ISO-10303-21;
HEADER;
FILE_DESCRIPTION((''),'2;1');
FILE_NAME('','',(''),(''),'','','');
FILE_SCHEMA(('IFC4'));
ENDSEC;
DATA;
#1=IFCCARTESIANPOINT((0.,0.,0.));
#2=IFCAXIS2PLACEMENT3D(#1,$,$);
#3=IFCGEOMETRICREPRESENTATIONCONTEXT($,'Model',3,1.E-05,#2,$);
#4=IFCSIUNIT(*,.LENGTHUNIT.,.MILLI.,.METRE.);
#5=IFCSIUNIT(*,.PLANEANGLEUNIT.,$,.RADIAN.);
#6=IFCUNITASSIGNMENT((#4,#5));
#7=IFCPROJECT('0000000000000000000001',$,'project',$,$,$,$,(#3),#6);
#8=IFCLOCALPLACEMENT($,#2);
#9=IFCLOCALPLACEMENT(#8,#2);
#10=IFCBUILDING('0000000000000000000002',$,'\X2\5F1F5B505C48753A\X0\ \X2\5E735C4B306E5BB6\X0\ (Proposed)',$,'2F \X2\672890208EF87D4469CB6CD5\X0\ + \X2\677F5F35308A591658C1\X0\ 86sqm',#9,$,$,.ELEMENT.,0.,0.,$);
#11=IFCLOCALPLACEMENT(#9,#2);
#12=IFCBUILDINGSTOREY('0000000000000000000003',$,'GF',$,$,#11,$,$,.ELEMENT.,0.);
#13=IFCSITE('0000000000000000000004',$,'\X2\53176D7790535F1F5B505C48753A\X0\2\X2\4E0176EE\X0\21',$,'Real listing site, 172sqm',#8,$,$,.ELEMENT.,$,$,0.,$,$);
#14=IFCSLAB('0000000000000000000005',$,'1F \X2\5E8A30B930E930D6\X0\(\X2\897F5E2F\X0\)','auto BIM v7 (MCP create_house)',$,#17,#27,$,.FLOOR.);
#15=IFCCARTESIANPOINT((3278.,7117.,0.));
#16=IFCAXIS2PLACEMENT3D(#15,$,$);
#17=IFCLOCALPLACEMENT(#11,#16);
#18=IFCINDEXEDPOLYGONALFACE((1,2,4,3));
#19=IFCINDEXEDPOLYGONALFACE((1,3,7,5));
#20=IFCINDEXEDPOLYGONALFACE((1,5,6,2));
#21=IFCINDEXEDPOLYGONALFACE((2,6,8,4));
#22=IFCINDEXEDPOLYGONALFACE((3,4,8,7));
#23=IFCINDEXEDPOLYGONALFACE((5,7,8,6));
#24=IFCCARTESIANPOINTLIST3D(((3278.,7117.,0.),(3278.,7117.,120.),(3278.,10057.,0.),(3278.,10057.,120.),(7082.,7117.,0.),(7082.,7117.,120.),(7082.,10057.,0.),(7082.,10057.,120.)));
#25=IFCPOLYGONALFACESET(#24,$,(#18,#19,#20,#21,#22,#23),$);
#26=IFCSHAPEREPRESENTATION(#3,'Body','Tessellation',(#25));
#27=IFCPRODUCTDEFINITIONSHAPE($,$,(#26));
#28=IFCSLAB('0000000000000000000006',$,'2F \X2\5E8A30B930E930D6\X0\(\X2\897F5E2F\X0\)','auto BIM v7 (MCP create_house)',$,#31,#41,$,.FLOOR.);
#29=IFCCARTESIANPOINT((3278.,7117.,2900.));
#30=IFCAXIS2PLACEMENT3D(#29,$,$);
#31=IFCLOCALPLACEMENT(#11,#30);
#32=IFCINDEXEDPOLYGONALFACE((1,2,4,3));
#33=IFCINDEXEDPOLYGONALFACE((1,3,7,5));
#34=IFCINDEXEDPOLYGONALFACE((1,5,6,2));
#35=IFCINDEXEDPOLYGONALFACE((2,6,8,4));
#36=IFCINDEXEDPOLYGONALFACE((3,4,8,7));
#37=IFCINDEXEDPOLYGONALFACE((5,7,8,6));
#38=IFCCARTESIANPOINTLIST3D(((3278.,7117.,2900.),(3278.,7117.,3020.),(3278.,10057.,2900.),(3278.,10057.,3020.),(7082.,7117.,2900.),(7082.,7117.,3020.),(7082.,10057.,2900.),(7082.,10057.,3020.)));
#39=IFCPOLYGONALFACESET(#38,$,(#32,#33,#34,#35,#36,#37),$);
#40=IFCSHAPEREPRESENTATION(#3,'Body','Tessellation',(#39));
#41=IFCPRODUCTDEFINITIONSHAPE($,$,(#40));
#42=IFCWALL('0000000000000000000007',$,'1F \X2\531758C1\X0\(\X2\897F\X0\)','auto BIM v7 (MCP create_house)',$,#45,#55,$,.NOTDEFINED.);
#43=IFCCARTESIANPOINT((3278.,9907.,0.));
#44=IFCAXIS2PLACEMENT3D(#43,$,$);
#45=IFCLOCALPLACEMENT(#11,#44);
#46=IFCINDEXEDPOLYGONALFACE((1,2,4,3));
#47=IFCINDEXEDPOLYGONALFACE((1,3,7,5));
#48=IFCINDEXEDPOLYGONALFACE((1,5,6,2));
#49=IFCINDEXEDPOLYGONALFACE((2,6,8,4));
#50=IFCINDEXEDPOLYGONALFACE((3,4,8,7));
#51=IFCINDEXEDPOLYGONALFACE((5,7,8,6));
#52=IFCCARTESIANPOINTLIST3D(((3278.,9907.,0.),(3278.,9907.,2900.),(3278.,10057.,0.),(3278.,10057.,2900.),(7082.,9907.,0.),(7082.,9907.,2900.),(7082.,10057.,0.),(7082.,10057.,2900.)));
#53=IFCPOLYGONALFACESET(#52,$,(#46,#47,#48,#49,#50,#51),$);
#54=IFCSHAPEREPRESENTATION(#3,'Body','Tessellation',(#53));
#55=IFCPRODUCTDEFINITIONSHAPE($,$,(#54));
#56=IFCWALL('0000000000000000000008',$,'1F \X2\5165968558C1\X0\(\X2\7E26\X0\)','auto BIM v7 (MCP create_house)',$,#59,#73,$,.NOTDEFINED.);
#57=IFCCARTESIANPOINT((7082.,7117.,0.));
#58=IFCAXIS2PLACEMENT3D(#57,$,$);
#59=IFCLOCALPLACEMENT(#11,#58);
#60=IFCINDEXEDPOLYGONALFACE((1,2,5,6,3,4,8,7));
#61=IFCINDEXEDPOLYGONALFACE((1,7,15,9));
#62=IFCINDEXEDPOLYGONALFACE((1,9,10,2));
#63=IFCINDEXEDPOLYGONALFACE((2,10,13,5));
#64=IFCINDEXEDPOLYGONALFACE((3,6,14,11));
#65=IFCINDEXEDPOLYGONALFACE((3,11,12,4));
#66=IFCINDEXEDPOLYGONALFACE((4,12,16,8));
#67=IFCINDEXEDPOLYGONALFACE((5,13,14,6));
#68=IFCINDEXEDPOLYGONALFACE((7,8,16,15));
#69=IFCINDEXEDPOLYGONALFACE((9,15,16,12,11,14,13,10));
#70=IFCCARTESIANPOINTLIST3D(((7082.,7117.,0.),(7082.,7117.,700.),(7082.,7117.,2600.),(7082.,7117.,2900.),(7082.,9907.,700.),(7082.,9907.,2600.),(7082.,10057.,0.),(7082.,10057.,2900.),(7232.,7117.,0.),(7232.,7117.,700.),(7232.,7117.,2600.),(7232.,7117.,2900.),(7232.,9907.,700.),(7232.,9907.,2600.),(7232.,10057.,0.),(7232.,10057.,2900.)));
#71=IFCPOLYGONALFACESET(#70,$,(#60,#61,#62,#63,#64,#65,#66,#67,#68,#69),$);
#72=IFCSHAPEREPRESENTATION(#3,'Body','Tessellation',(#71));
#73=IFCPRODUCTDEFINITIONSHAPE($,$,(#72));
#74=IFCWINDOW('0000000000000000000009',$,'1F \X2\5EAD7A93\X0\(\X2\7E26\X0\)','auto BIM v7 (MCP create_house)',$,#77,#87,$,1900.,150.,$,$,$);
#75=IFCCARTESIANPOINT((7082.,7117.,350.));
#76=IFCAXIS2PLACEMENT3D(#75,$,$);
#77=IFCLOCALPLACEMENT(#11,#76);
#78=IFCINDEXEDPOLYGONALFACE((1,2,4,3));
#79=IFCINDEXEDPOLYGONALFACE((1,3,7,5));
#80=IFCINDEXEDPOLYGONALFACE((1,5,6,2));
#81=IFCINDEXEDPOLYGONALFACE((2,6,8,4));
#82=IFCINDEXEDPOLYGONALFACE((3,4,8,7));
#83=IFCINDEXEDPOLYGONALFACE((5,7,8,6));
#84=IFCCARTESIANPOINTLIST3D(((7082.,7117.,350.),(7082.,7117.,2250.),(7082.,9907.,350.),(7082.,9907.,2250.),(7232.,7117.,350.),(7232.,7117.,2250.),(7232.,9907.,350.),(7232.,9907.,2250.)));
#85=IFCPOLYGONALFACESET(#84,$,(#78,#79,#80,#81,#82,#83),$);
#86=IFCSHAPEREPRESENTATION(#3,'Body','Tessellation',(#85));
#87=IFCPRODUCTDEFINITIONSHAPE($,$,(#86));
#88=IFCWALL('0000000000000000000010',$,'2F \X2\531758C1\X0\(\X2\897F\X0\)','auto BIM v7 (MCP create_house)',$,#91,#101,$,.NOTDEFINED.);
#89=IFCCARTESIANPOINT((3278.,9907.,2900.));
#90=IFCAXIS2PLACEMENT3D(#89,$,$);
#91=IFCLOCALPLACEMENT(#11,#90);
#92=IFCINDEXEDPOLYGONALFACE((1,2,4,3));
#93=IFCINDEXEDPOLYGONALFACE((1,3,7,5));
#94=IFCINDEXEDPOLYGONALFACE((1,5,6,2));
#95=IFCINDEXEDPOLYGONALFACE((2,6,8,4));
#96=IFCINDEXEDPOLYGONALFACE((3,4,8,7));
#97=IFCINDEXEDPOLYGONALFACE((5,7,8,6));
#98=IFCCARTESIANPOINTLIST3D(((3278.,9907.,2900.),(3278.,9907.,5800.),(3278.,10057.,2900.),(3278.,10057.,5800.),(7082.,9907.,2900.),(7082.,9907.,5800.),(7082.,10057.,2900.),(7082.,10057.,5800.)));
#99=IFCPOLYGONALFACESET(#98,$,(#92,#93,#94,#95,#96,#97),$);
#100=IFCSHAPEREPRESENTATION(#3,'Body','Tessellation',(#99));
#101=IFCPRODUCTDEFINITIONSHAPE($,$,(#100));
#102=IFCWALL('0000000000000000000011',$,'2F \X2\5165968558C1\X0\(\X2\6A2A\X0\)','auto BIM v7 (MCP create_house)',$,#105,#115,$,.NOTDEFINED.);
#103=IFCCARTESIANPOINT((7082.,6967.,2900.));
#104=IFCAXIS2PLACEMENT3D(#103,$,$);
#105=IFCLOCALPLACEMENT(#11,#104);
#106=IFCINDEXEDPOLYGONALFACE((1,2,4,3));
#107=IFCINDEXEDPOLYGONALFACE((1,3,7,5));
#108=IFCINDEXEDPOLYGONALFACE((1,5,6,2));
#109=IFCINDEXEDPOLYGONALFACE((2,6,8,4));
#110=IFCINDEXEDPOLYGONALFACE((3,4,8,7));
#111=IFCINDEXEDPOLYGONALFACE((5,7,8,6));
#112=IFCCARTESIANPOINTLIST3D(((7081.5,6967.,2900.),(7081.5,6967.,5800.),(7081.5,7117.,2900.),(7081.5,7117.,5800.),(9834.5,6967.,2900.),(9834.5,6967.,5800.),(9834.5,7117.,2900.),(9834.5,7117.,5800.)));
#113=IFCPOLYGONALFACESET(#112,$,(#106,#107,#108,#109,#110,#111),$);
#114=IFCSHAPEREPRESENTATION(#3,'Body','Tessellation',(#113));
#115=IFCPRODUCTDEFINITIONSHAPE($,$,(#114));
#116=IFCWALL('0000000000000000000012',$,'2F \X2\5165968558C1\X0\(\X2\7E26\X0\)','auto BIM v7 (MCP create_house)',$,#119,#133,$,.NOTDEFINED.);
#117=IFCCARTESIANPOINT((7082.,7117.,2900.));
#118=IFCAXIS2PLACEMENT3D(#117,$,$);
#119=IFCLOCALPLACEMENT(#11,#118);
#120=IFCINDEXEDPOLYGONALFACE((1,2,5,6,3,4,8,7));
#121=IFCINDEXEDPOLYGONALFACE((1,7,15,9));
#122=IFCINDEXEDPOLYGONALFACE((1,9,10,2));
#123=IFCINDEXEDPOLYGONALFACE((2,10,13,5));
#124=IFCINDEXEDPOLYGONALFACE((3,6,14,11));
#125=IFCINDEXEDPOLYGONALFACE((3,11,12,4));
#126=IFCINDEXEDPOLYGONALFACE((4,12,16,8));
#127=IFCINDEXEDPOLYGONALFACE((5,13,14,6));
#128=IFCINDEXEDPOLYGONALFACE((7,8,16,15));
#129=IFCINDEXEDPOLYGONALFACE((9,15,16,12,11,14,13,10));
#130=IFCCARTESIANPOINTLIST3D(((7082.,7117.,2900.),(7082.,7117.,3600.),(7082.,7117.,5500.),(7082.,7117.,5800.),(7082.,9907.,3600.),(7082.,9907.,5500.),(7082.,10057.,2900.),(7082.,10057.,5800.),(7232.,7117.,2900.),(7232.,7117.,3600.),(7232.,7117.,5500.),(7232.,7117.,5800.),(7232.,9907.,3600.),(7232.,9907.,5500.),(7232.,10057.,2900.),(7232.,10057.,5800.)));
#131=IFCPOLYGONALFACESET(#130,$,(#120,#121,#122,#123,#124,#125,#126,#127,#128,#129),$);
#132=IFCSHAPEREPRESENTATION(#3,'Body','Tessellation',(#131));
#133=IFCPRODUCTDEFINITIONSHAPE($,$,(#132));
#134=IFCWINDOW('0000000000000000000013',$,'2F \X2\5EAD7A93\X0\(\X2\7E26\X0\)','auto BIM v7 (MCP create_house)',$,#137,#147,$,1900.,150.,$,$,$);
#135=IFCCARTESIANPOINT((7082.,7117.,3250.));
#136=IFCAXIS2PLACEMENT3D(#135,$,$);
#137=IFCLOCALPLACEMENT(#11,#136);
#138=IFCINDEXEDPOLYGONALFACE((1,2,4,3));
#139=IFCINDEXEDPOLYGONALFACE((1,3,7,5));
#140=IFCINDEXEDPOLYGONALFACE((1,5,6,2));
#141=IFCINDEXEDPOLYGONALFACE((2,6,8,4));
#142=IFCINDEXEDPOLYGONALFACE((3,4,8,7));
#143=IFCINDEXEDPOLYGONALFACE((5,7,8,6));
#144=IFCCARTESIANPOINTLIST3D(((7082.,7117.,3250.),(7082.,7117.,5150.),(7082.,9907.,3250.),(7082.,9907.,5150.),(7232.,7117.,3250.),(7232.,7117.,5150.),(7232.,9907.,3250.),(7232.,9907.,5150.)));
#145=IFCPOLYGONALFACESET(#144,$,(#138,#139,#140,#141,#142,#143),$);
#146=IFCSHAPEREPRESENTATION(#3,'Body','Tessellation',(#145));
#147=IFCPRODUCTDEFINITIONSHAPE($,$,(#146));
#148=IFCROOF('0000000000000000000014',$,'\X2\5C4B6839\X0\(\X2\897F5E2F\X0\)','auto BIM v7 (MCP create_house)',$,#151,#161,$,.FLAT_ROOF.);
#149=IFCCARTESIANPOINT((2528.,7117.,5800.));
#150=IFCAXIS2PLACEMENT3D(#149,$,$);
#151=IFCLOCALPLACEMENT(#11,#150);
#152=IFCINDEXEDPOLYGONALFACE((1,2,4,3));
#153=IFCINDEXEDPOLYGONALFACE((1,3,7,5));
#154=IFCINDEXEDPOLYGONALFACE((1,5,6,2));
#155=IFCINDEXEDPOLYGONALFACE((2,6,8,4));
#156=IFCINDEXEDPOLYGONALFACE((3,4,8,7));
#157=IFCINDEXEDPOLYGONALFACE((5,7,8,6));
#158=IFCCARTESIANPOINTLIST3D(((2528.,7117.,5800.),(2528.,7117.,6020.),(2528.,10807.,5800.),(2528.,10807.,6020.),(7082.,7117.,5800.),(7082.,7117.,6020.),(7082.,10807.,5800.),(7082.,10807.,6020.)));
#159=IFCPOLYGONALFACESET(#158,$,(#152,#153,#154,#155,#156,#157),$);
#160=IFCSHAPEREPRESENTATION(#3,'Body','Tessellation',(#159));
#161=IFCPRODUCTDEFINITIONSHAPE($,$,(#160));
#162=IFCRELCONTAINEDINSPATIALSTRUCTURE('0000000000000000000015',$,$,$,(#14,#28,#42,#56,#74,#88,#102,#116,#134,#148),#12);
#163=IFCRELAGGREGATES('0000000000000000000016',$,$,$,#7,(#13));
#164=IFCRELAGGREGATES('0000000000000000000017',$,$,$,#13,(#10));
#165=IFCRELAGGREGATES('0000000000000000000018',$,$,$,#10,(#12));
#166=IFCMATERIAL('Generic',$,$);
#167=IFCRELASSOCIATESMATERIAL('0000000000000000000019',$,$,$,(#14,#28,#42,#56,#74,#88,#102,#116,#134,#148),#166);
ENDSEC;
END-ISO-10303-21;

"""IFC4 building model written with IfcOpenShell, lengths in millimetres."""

from ifc_helpers import new_model, si_unit, frame, frame_2d, origin, place, context, project, spatial, rectangle, extrude, material, element, fill, save


model = new_model("IFC4")

# Units and contexts
model_context = context("Model", 3, precision=1e-05, world=origin())
ifc_project = project(units=[si_unit("LENGTHUNIT", "METRE", prefix="MILLI"), si_unit("PLANEANGLEUNIT", "RADIAN")], contexts=[model_context])

# Site, building, storey
site_placement = place(None, origin())
site = spatial("IfcSite", under=ifc_project, at=site_placement, Name="北海道弟子屈町2丁目21", ObjectType="Real listing site, 172sqm", CompositionType="ELEMENT", RefElevation=0.0)
building_placement = place(site_placement, origin())
building = spatial("IfcBuilding", under=site, at=building_placement, Name="弟子屈町 平屋の家 (Proposed)", ObjectType="2F 木造軸組構法 + 板張り外壁 86sqm", CompositionType="ELEMENT", ElevationOfRefHeight=0.0, ElevationOfTerrain=0.0)
storey_placement = place(building_placement, origin())
storey = spatial("IfcBuildingStorey", under=building, at=storey_placement, Name="GF", CompositionType="ELEMENT", Elevation=0.0)

# Slabs
ifc_material = material(Name="Generic")
slab_1_placement = place(storey_placement, frame((3278.0, 7117.0, 0.0)))
element("IfcSlab", 1, at=slab_1_placement, inside=storey, material=ifc_material, Name="1F 床スラブ(西帯)", Description="auto BIM v7 (MCP create_house)", PredefinedType="FLOOR", context=model_context, shape_type="SweptSolid", body=[
    extrude(rectangle(XDim=3804.0, YDim=2940.0, at=frame_2d((1902.0, 1470.0))), frame((3278.0, 7117.0, 0.0)), (0.0, 0.0, 1.0), 120.0),
])
slab_2_placement = place(storey_placement, frame((3278.0, 7117.0, 2900.0)))
element("IfcSlab", 2, at=slab_2_placement, inside=storey, material=ifc_material, Name="2F 床スラブ(西帯)", Description="auto BIM v7 (MCP create_house)", PredefinedType="FLOOR", context=model_context, shape_type="SweptSolid", body=[
    extrude(rectangle(XDim=3804.0, YDim=2940.0, at=frame_2d((1902.0, 1470.0))), frame((3278.0, 7117.0, 2900.0)), (0.0, 0.0, 1.0), 120.0),
])

# Wall
wall_1_placement = place(storey_placement, frame((3278.0, 9907.0, 0.0)))
element("IfcWall", 3, at=wall_1_placement, inside=storey, material=ifc_material, Name="1F 北壁(西)", Description="auto BIM v7 (MCP create_house)", PredefinedType="NOTDEFINED", context=model_context, shape_type="SweptSolid", body=[
    extrude(rectangle(XDim=3804.0, YDim=150.0, at=frame_2d((1902.0, 75.0))), frame((3278.0, 9907.0, 0.0)), (0.0, 0.0, 1.0), 2900.0),
])

# Wall, opening, window
wall_2_placement = place(storey_placement, frame((7082.0, 7117.0, 0.0)))
wall_2 = element("IfcWall", 4, at=wall_2_placement, inside=storey, material=ifc_material, Name="1F 入隅壁(縦)", Description="auto BIM v7 (MCP create_house)", PredefinedType="NOTDEFINED", context=model_context, shape_type="SweptSolid", body=[
    extrude(rectangle(XDim=150.0, YDim=2940.0, at=frame_2d((75.0, 1470.0))), frame((7082.0, 7117.0, 0.0)), (0.0, 0.0, 1.0), 2900.0),
])
opening_1_placement = place(storey_placement, frame((7082.0, 7117.0, 350.0)))
opening_1 = element("IfcOpeningElement", 5, at=opening_1_placement, cuts=wall_2, PredefinedType="NOTDEFINED", context=model_context, shape_type="SweptSolid", body=[
    extrude(rectangle(XDim=150.0, YDim=2790.0, at=frame_2d((75.0, 1395.0))), frame((7082.0, 7117.0, 350.0)), (0.0, 0.0, 1.0), 1900.0),
])
window_1_placement = place(storey_placement, frame((7082.0, 7117.0, 350.0)))
window_1 = element("IfcWindow", 6, at=window_1_placement, inside=storey, material=ifc_material, Name="1F 庭窓(縦)", Description="auto BIM v7 (MCP create_house)", OverallHeight=1900.0, OverallWidth=150.0, context=model_context, shape_type="SweptSolid", body=[
    extrude(rectangle(XDim=150.0, YDim=2790.0, at=frame_2d((75.0, 1395.0))), frame((7082.0, 7117.0, 350.0)), (0.0, 0.0, 1.0), 1900.0),
])
fill(opening_1, window_1)

# Walls
wall_3_placement = place(storey_placement, frame((3278.0, 9907.0, 2900.0)))
element("IfcWall", 7, at=wall_3_placement, inside=storey, material=ifc_material, Name="2F 北壁(西)", Description="auto BIM v7 (MCP create_house)", PredefinedType="NOTDEFINED", context=model_context, shape_type="SweptSolid", body=[
    extrude(rectangle(XDim=3804.0, YDim=150.0, at=frame_2d((1902.0, 75.0))), frame((3278.0, 9907.0, 2900.0)), (0.0, 0.0, 1.0), 2900.0),
])
wall_4_placement = place(storey_placement, frame((7082.0, 6967.0, 2900.0)))
element("IfcWall", 8, at=wall_4_placement, inside=storey, material=ifc_material, Name="2F 入隅壁(横)", Description="auto BIM v7 (MCP create_house)", PredefinedType="NOTDEFINED", context=model_context, shape_type="SweptSolid", body=[
    extrude(rectangle(XDim=2753.0, YDim=150.0, at=frame_2d((1376.0, 75.0))), frame((7082.0, 6967.0, 2900.0)), (0.0, 0.0, 1.0), 2900.0),
])

# Wall, opening, window
wall_5_placement = place(storey_placement, frame((7082.0, 7117.0, 2900.0)))
wall_5 = element("IfcWall", 9, at=wall_5_placement, inside=storey, material=ifc_material, Name="2F 入隅壁(縦)", Description="auto BIM v7 (MCP create_house)", PredefinedType="NOTDEFINED", context=model_context, shape_type="SweptSolid", body=[
    extrude(rectangle(XDim=150.0, YDim=2940.0, at=frame_2d((75.0, 1470.0))), frame((7082.0, 7117.0, 2900.0)), (0.0, 0.0, 1.0), 2900.0),
])
opening_2_placement = place(storey_placement, frame((7082.0, 7117.0, 3250.0)))
opening_2 = element("IfcOpeningElement", 10, at=opening_2_placement, cuts=wall_5, PredefinedType="NOTDEFINED", context=model_context, shape_type="SweptSolid", body=[
    extrude(rectangle(XDim=150.0, YDim=2790.0, at=frame_2d((75.0, 1395.0))), frame((7082.0, 7117.0, 3250.0)), (0.0, 0.0, 1.0), 1900.0),
])
window_2_placement = place(storey_placement, frame((7082.0, 7117.0, 3250.0)))
window_2 = element("IfcWindow", 11, at=window_2_placement, inside=storey, material=ifc_material, Name="2F 庭窓(縦)", Description="auto BIM v7 (MCP create_house)", OverallHeight=1900.0, OverallWidth=150.0, context=model_context, shape_type="SweptSolid", body=[
    extrude(rectangle(XDim=150.0, YDim=2790.0, at=frame_2d((75.0, 1395.0))), frame((7082.0, 7117.0, 3250.0)), (0.0, 0.0, 1.0), 1900.0),
])
fill(opening_2, window_2)

# Roof
for number, where, name in (
    (12, (2528.0, 7117.0, 5800.0), "屋根(西帯)"),
):
    element("IfcRoof", number, at=place(storey_placement, frame(where)), inside=storey, material=ifc_material, Name=name, Description="auto BIM v7 (MCP create_house)", PredefinedType="FLAT_ROOF", context=model_context, shape_type="SweptSolid", body=[
        extrude(rectangle(XDim=4554.0, YDim=3690.0, at=frame_2d((2277.0, 1845.0))), frame((2528.0, 7117.0, 5800.0)), (0.0, 0.0, 1.0), 220.0),
    ])

save(model, "model.ifc")
